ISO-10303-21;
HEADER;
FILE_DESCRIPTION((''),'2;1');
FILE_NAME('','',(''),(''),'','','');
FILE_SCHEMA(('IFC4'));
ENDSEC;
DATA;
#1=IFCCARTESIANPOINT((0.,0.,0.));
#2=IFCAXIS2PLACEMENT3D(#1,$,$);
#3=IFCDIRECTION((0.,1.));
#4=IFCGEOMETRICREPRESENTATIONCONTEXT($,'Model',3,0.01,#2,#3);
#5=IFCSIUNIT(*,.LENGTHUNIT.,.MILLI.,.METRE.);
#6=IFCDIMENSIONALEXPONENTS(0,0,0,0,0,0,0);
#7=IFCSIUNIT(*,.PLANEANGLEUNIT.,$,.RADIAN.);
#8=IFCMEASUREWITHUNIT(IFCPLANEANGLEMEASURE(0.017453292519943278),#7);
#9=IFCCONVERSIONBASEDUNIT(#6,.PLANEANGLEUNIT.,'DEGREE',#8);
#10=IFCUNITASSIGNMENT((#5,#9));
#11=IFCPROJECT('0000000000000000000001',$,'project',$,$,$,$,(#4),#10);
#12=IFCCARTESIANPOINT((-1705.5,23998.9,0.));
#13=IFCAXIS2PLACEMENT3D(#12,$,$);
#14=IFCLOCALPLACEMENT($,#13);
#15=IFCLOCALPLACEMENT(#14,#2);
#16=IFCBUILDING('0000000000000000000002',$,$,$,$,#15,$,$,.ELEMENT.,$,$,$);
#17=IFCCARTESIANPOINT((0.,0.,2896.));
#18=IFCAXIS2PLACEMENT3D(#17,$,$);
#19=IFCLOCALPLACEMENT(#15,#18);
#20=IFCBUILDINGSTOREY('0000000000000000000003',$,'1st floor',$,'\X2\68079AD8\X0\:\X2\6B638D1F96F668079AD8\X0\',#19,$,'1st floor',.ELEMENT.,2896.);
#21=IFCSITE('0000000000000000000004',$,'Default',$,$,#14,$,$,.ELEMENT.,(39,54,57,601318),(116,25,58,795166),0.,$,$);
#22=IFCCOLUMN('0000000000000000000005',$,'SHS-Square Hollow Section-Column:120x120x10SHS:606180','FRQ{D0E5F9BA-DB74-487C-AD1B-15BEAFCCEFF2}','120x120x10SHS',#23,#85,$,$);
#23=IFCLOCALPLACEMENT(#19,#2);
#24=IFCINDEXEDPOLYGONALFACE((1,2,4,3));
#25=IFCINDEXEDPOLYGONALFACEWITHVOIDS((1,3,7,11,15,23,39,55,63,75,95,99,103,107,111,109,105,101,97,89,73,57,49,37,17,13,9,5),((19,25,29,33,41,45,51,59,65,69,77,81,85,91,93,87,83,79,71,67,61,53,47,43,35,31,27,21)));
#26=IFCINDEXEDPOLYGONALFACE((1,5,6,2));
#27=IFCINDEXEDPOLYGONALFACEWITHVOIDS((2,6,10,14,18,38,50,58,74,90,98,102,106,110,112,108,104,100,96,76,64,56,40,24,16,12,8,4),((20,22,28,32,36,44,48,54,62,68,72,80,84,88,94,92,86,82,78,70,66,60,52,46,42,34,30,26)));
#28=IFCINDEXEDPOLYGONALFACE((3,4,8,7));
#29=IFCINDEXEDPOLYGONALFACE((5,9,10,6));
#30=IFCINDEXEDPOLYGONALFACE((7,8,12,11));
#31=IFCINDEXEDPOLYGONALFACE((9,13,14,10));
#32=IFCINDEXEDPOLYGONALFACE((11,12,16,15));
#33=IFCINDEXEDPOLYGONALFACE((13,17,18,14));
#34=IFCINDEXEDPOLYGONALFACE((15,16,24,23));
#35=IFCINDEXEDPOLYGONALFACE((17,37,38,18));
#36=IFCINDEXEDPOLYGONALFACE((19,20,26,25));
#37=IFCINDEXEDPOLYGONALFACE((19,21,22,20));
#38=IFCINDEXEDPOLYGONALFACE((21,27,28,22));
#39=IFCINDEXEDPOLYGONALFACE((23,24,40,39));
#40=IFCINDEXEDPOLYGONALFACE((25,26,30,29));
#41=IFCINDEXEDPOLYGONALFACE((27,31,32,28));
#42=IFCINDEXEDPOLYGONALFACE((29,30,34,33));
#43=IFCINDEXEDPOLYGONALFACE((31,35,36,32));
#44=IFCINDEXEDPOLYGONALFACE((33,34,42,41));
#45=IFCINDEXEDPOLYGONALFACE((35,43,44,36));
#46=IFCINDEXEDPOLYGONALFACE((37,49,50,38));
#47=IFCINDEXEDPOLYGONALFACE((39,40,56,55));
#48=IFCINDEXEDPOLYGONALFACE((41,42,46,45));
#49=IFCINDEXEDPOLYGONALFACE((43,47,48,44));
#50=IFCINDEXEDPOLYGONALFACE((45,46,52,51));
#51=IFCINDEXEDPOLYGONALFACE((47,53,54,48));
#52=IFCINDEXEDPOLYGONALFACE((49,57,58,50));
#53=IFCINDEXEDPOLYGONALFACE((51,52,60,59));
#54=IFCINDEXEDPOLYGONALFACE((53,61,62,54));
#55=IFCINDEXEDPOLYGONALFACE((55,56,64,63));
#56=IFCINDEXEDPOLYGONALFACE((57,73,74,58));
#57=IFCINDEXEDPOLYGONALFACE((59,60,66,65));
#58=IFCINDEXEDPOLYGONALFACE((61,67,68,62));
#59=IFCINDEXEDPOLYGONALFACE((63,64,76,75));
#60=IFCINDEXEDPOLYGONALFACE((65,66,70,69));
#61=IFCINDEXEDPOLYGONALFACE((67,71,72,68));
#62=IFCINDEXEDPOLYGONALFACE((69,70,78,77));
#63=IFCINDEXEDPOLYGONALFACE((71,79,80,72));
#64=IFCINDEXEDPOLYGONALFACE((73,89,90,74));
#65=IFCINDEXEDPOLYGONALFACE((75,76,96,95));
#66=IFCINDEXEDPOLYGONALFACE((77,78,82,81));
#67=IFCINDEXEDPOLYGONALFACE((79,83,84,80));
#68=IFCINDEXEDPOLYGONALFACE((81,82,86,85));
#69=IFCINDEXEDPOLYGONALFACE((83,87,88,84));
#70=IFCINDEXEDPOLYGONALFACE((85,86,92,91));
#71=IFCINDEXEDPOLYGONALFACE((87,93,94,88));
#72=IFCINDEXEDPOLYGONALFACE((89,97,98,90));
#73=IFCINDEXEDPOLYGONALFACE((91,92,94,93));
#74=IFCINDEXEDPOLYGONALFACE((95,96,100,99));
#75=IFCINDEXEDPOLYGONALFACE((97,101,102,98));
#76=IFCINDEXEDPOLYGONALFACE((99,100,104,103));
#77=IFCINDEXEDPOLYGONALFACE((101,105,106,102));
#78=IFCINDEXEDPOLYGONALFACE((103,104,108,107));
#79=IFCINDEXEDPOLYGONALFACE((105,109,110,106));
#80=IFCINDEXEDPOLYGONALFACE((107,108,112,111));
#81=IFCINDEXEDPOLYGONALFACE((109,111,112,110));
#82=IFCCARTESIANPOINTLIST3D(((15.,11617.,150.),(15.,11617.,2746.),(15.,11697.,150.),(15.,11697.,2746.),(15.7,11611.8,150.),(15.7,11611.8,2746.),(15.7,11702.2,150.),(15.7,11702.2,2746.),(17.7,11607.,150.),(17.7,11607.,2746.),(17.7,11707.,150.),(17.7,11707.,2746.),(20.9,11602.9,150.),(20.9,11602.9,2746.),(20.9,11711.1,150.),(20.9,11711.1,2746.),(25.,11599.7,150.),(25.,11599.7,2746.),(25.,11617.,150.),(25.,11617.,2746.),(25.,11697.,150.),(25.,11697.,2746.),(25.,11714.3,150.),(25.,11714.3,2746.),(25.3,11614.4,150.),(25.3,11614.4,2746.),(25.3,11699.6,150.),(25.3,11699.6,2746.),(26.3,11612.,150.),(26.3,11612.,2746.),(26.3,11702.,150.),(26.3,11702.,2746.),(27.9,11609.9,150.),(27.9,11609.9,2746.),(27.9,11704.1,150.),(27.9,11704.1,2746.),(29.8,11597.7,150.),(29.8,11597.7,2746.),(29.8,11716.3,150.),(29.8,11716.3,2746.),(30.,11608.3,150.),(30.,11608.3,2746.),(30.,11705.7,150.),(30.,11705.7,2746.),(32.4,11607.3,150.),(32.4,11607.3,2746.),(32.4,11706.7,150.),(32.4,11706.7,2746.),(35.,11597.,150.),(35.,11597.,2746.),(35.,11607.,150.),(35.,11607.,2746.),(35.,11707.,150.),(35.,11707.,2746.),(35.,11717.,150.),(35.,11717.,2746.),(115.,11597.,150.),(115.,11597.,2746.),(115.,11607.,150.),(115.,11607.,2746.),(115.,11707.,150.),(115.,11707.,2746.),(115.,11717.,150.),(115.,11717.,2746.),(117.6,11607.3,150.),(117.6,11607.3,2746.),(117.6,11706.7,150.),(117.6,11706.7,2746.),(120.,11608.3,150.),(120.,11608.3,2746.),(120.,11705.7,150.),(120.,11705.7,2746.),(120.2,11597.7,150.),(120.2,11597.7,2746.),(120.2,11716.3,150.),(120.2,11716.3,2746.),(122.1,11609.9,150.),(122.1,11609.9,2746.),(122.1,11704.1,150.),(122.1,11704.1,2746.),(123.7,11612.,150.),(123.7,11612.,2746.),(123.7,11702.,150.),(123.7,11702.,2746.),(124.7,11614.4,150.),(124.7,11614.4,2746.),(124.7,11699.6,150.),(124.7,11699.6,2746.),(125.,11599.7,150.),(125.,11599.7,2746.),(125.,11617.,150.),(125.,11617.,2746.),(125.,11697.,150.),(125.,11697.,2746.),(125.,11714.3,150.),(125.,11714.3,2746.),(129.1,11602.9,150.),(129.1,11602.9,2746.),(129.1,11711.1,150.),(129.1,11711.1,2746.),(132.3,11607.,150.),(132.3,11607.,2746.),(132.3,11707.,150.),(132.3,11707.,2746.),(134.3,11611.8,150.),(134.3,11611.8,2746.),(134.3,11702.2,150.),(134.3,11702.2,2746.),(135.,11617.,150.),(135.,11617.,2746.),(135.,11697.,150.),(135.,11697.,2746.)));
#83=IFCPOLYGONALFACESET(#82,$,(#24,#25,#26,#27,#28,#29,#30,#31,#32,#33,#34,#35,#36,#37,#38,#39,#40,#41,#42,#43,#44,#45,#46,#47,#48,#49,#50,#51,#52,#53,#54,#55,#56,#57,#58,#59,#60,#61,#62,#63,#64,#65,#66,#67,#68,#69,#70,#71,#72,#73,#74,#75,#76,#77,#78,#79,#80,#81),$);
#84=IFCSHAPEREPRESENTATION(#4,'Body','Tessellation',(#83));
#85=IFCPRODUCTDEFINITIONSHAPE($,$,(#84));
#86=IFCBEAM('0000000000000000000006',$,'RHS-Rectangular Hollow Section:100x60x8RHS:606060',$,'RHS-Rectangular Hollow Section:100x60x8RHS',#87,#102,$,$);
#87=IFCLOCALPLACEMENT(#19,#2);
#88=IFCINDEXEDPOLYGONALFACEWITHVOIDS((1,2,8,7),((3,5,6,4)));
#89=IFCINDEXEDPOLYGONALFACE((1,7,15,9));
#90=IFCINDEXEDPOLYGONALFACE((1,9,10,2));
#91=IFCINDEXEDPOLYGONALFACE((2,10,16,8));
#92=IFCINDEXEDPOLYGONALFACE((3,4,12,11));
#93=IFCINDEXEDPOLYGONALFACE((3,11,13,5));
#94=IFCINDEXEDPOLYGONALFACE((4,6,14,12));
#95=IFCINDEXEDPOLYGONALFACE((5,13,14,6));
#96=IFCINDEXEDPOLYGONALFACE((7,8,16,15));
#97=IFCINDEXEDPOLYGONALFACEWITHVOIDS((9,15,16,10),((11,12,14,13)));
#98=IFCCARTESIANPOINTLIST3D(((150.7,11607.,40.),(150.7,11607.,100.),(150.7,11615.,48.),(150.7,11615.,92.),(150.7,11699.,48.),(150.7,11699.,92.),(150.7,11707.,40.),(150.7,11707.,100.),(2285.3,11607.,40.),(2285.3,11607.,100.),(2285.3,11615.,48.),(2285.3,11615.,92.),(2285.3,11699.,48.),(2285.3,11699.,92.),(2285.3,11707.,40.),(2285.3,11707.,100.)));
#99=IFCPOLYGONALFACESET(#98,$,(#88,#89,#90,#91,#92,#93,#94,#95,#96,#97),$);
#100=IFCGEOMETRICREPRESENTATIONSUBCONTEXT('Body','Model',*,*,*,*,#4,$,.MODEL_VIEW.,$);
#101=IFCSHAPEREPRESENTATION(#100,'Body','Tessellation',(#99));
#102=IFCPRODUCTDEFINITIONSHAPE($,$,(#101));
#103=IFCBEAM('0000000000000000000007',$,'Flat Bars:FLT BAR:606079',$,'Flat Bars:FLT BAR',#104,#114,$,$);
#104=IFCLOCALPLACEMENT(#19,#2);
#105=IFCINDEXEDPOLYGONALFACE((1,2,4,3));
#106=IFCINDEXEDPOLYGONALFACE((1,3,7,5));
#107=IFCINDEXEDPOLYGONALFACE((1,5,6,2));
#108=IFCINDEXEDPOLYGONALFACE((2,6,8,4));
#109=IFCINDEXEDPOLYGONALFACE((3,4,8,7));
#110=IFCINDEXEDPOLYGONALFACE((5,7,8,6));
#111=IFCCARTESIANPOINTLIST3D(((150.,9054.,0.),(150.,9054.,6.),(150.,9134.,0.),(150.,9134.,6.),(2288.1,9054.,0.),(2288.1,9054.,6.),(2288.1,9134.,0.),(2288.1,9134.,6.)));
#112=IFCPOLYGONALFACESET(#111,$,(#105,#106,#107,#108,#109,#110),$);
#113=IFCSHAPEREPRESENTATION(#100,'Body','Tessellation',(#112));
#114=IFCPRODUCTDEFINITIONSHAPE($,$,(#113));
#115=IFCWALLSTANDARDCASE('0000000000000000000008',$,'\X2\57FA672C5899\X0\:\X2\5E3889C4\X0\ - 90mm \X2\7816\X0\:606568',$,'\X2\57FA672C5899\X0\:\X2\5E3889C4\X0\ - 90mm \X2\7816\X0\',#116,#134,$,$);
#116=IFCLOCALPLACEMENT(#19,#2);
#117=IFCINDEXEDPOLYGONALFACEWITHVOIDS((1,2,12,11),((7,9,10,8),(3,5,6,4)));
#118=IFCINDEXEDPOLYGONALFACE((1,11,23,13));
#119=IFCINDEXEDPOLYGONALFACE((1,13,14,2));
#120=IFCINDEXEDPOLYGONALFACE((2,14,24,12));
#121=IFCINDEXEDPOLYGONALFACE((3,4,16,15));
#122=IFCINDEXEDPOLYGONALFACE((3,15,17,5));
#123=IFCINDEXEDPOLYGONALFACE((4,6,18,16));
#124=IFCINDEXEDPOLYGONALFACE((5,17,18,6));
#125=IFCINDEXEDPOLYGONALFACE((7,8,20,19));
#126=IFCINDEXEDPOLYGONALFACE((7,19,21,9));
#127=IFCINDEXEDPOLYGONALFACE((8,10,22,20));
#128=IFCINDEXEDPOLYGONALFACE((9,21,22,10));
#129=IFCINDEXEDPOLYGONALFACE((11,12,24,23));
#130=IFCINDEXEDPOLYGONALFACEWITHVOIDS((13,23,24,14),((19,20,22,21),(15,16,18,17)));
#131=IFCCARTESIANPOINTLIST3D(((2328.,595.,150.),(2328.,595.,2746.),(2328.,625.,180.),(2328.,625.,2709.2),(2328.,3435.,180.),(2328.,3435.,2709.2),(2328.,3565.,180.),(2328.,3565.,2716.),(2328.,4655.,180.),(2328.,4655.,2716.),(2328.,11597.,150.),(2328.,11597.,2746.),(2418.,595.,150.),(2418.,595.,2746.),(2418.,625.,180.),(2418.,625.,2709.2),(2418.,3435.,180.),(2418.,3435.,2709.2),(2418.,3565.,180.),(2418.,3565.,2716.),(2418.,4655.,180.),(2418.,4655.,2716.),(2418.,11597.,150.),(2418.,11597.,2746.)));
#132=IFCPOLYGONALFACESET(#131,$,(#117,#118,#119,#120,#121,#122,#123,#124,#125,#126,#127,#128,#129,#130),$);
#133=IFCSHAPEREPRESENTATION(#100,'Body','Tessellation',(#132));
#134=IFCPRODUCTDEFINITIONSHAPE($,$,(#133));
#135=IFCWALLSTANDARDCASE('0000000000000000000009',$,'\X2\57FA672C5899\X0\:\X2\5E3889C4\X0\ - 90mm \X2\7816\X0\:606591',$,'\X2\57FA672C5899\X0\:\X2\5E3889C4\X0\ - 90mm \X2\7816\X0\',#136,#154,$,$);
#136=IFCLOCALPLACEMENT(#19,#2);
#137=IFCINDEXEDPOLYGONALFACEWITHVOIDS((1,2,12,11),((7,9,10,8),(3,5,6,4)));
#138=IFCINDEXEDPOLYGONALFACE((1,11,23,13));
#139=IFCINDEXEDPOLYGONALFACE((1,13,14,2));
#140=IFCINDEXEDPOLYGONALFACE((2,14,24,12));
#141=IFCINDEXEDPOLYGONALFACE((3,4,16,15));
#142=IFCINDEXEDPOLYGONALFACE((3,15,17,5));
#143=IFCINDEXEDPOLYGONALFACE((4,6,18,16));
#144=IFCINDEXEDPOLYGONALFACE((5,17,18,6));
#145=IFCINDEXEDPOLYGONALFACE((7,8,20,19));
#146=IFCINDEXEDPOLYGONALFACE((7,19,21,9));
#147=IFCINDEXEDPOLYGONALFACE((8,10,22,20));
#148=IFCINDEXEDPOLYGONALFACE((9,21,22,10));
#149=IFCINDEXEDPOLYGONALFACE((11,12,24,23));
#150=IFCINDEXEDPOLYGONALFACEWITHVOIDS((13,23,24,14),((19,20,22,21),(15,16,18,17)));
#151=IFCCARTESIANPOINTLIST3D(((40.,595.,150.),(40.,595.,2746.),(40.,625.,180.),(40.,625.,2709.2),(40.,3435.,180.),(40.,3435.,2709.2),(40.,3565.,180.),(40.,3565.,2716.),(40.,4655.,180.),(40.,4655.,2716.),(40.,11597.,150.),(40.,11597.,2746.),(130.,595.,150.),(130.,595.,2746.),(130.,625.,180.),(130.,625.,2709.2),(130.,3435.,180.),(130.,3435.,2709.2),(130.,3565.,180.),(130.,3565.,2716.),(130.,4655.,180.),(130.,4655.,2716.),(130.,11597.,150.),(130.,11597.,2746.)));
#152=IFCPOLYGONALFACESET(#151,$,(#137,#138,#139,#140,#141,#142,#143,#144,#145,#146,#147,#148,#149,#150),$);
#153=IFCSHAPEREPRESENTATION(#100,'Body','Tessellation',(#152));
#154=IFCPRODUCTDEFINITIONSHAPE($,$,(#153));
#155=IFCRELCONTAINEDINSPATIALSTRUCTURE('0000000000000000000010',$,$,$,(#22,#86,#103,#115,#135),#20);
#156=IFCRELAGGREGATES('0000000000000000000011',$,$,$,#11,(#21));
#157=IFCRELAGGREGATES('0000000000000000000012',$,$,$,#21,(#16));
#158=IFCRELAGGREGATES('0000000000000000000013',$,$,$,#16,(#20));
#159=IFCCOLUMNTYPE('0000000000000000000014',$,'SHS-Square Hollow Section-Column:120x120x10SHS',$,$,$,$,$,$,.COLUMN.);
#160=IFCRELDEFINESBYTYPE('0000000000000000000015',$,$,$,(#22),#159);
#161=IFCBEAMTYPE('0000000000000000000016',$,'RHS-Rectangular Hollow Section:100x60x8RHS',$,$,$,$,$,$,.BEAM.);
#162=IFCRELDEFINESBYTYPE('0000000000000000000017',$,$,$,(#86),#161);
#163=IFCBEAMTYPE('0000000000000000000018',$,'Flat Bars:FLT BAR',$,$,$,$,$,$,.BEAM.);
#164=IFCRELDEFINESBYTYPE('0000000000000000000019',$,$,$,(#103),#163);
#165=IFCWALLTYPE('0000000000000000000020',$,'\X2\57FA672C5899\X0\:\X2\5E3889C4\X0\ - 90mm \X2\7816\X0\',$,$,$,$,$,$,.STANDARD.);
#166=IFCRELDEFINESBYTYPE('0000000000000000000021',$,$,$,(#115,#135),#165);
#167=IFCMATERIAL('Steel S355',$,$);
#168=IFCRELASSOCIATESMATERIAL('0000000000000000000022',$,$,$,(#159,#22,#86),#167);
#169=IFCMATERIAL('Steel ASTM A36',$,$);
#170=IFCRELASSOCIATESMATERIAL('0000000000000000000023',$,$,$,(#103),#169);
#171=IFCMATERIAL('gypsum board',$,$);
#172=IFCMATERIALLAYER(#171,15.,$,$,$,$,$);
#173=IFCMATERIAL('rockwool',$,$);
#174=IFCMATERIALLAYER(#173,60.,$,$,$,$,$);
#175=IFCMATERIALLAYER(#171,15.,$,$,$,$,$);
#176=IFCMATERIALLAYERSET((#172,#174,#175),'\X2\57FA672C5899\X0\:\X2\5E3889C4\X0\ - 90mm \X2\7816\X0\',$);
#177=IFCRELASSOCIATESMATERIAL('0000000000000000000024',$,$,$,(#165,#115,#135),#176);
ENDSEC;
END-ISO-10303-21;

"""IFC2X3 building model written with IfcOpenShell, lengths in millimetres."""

from ifc_helpers import new_model, entity, si_unit, converted_unit, direction, frame, frame_2d, origin, origin_2d, origin_2d_with_axis, place, context, subcontext, project, spatial, rectangle, hollow_rectangle, extrude, boolean, clip, halfspace, material, layer, layer_set, layer_usage, type_object, element, save


model = new_model("IFC2X3")

# Units and contexts
model_context = context("Model", 3, precision=0.01, world=origin(), true_north=direction((0.0, 1.0)))
body_context = subcontext(model_context, "Body", "Model", "MODEL_VIEW")
ifc_project = project(units=[si_unit("LENGTHUNIT", "METRE", prefix="MILLI"), converted_unit("PLANEANGLEUNIT", "DEGREE", entity("IfcPlaneAngleMeasure", 0.017453292519943278), si_unit("PLANEANGLEUNIT", "RADIAN"), dimensions=[0, 0, 0, 0, 0, 0, 0])], contexts=[model_context])

# Site, building, storey
site_placement = place(None, frame((-1705.5, 23998.9, 0.0)))
site = spatial("IfcSite", under=ifc_project, at=site_placement, Name="Default", CompositionType="ELEMENT", RefLatitude=(39, 54, 57, 601318), RefLongitude=(116, 25, 58, 795166), RefElevation=0.0)
building_placement = place(site_placement, origin())
building = spatial("IfcBuilding", under=site, at=building_placement, CompositionType="ELEMENT")
storey_placement = place(building_placement, frame((0.0, 0.0, 2896.0)))
storey = spatial("IfcBuildingStorey", under=building, at=storey_placement, Name="1st floor", ObjectType="标高:正负零标高", LongName="1st floor", CompositionType="ELEMENT", Elevation=2896.0)

# Shared definitions
ifc_material_1 = material(Name="Steel S355")

# Column
column_type_1 = type_object("IfcColumnType", Name="SHS-Square Hollow Section-Column:120x120x10SHS", PredefinedType="COLUMN", material=ifc_material_1)
column_1_placement = place(storey_placement, frame((75.0, 11657.0, 2830.9), z_axis=(0.0, 0.0, 1.0), x_axis=(0.0, -1.0, 0.0)))
element("IfcColumn", 1, at=column_1_placement, inside=storey, type_object=column_type_1, material=ifc_material_1, Name="SHS-Square Hollow Section-Column:120x120x10SHS:606180", Description="FRQ{D0E5F9BA-DB74-487C-AD1B-15BEAFCCEFF2}", ObjectType="120x120x10SHS", context=model_context, shape_type="Clipping", body=[
    clip(clip(extrude(hollow_rectangle(XDim=120.0, YDim=120.0, WallThickness=10.0, InnerFilletRadius=10.0, OuterFilletRadius=20.0, at=origin_2d()), origin(), (0.0, 0.0, -1.0), 2765.7), halfspace(frame((11657.0, -75.0, -84.9), z_axis=(0.0, 0.0, -1.0), x_axis=(0.0, -1.0, 0.0)), True)), halfspace(frame((11657.0, -75.0, -2680.9), z_axis=(0.0, 0.0, 1.0), x_axis=(0.0, 1.0, 0.0)), True)),
])

# Beams
beam_type_1 = type_object("IfcBeamType", Name="RHS-Rectangular Hollow Section:100x60x8RHS", PredefinedType="BEAM")
beam_1_placement = place(storey_placement, frame((150.7, 11707.0, 70.0)))
element("IfcBeam", 2, at=beam_1_placement, inside=storey, type_object=beam_type_1, material=ifc_material_1, Name="RHS-Rectangular Hollow Section:100x60x8RHS:606060", ObjectType="RHS-Rectangular Hollow Section:100x60x8RHS", context=body_context, shape_type="SweptSolid", body=[
    boolean("DIFFERENCE", extrude(rectangle(XDim=60.0, YDim=100.0, at=frame_2d((0.0, 0.0), x_axis=(1.0, 0.0))), frame((0.0, -50.0, 0.0), z_axis=(1.0, 0.0, 0.0), x_axis=(0.0, 0.0, -1.0)), (0.0, 0.0, 1.0), 2134.6), extrude(rectangle(XDim=44.0, YDim=84.0, at=frame_2d((0.0, 0.0), x_axis=(0.0, 1.0))), frame((2134.6, -50.0, 0.0), z_axis=(-1.0, 0.0, 0.0), x_axis=(0.0, 1.0, 0.0)), (0.0, 0.0, 1.0), 2134.6)),
])
ifc_material_2 = material(Name="Steel ASTM A36")
beam_type_2 = type_object("IfcBeamType", Name="Flat Bars:FLT BAR", PredefinedType="BEAM")
beam_2_placement = place(storey_placement, frame((150.0, 9094.0, 6.0)))
element("IfcBeam", 3, at=beam_2_placement, inside=storey, type_object=beam_type_2, material=ifc_material_2, Name="Flat Bars:FLT BAR:606079", ObjectType="Flat Bars:FLT BAR", context=body_context, shape_type="SweptSolid", body=[
    extrude(rectangle(XDim=6.0, YDim=80.0, at=origin_2d_with_axis()), frame((0.0, 0.0, -3.0), z_axis=(1.0, 0.0, 0.0), x_axis=(0.0, 0.0, -1.0)), (0.0, 0.0, 1.0), 2138.1),
])

# Shared definitions
ifc_material_3 = material(Name="gypsum board")
ifc_layer_1 = layer(ifc_material_3, 15.0)
ifc_material_4 = material(Name="rockwool")
ifc_layer_2 = layer(ifc_material_4, 60.0)
ifc_layer_3 = layer(ifc_material_3, 15.0)
ifc_layer_set = layer_set([ifc_layer_1, ifc_layer_2, ifc_layer_3], Name="基本墙:常规 - 90mm 砖")
wall_type = type_object("IfcWallType", Name="基本墙:常规 - 90mm 砖", PredefinedType="STANDARD", material=ifc_layer_set)

# Walls, openings
ifc_layer_usage_1 = layer_usage(ifc_layer_set, "AXIS2", "NEGATIVE", 45.0)
wall_1_placement = place(storey_placement, frame((2373.0, 11597.0, 150.0), z_axis=(0.0, 0.0, 1.0), x_axis=(0.0, -1.0, 0.0)))
wall_1 = element("IfcWallStandardCase", 4, at=wall_1_placement, inside=storey, type_object=wall_type, material=ifc_layer_usage_1, Name="基本墙:常规 - 90mm 砖:606568", ObjectType="基本墙:常规 - 90mm 砖", context=body_context, shape_type="SweptSolid", body=[
    extrude(rectangle(XDim=11002.0, YDim=90.0, at=frame_2d((5501.0, 0.0), x_axis=(-1.0, 0.0))), origin(), (0.0, 0.0, 1.0), 2596.0),
])
opening_1_placement = place(wall_1_placement, origin())
element("IfcOpeningElement", 5, at=opening_1_placement, cuts=wall_1, ObjectType="Opening", context=body_context, shape_type="SweptSolid", body=[
    extrude(rectangle(XDim=2536.0, YDim=1090.0, at=frame_2d((0.0, 0.0), x_axis=(0.0, 1.0))), frame((7487.0, 45.0, 1298.0), z_axis=(0.0, -1.0, 0.0), x_axis=(-1.0, 0.0, 0.0)), (0.0, 0.0, 1.0), 90.0),
])
opening_2_placement = place(wall_1_placement, origin())
element("IfcOpeningElement", 6, at=opening_2_placement, cuts=wall_1, ObjectType="Opening", context=body_context, shape_type="SweptSolid", body=[
    extrude(rectangle(XDim=2529.2, YDim=2810.0, at=frame_2d((0.0, 0.0), x_axis=(0.0, 1.0))), frame((9567.0, 45.0, 1294.6), z_axis=(0.0, -1.0, 0.0), x_axis=(-1.0, 0.0, 0.0)), (0.0, 0.0, 1.0), 90.0),
])
ifc_layer_usage_2 = layer_usage(ifc_layer_set, "AXIS2", "NEGATIVE", 45.0)
wall_2_placement = place(storey_placement, frame((85.0, 11597.0, 150.0), z_axis=(0.0, 0.0, 1.0), x_axis=(0.0, -1.0, 0.0)))
wall_2 = element("IfcWallStandardCase", 7, at=wall_2_placement, inside=storey, type_object=wall_type, material=ifc_layer_usage_2, Name="基本墙:常规 - 90mm 砖:606591", ObjectType="基本墙:常规 - 90mm 砖", context=body_context, shape_type="SweptSolid", body=[
    extrude(rectangle(XDim=11002.0, YDim=90.0, at=frame_2d((5501.0, 0.0), x_axis=(-1.0, 0.0))), origin(), (0.0, 0.0, 1.0), 2596.0),
])
opening_3_placement = place(wall_2_placement, origin())
element("IfcOpeningElement", 8, at=opening_3_placement, cuts=wall_2, ObjectType="Opening", context=body_context, shape_type="SweptSolid", body=[
    extrude(rectangle(XDim=2536.0, YDim=1090.0, at=frame_2d((0.0, 0.0), x_axis=(0.0, 1.0))), frame((7487.0, 45.0, 1298.0), z_axis=(0.0, -1.0, 0.0), x_axis=(-1.0, 0.0, 0.0)), (0.0, 0.0, 1.0), 90.0),
])
opening_4_placement = place(wall_2_placement, origin())
element("IfcOpeningElement", 9, at=opening_4_placement, cuts=wall_2, ObjectType="Opening", context=body_context, shape_type="SweptSolid", body=[
    extrude(rectangle(XDim=2529.2, YDim=2810.0, at=frame_2d((0.0, 0.0), x_axis=(0.0, 1.0))), frame((9567.0, 45.0, 1294.6), z_axis=(0.0, -1.0, 0.0), x_axis=(-1.0, 0.0, 0.0)), (0.0, 0.0, 1.0), 90.0),
])

save(model, "model.ifc")
